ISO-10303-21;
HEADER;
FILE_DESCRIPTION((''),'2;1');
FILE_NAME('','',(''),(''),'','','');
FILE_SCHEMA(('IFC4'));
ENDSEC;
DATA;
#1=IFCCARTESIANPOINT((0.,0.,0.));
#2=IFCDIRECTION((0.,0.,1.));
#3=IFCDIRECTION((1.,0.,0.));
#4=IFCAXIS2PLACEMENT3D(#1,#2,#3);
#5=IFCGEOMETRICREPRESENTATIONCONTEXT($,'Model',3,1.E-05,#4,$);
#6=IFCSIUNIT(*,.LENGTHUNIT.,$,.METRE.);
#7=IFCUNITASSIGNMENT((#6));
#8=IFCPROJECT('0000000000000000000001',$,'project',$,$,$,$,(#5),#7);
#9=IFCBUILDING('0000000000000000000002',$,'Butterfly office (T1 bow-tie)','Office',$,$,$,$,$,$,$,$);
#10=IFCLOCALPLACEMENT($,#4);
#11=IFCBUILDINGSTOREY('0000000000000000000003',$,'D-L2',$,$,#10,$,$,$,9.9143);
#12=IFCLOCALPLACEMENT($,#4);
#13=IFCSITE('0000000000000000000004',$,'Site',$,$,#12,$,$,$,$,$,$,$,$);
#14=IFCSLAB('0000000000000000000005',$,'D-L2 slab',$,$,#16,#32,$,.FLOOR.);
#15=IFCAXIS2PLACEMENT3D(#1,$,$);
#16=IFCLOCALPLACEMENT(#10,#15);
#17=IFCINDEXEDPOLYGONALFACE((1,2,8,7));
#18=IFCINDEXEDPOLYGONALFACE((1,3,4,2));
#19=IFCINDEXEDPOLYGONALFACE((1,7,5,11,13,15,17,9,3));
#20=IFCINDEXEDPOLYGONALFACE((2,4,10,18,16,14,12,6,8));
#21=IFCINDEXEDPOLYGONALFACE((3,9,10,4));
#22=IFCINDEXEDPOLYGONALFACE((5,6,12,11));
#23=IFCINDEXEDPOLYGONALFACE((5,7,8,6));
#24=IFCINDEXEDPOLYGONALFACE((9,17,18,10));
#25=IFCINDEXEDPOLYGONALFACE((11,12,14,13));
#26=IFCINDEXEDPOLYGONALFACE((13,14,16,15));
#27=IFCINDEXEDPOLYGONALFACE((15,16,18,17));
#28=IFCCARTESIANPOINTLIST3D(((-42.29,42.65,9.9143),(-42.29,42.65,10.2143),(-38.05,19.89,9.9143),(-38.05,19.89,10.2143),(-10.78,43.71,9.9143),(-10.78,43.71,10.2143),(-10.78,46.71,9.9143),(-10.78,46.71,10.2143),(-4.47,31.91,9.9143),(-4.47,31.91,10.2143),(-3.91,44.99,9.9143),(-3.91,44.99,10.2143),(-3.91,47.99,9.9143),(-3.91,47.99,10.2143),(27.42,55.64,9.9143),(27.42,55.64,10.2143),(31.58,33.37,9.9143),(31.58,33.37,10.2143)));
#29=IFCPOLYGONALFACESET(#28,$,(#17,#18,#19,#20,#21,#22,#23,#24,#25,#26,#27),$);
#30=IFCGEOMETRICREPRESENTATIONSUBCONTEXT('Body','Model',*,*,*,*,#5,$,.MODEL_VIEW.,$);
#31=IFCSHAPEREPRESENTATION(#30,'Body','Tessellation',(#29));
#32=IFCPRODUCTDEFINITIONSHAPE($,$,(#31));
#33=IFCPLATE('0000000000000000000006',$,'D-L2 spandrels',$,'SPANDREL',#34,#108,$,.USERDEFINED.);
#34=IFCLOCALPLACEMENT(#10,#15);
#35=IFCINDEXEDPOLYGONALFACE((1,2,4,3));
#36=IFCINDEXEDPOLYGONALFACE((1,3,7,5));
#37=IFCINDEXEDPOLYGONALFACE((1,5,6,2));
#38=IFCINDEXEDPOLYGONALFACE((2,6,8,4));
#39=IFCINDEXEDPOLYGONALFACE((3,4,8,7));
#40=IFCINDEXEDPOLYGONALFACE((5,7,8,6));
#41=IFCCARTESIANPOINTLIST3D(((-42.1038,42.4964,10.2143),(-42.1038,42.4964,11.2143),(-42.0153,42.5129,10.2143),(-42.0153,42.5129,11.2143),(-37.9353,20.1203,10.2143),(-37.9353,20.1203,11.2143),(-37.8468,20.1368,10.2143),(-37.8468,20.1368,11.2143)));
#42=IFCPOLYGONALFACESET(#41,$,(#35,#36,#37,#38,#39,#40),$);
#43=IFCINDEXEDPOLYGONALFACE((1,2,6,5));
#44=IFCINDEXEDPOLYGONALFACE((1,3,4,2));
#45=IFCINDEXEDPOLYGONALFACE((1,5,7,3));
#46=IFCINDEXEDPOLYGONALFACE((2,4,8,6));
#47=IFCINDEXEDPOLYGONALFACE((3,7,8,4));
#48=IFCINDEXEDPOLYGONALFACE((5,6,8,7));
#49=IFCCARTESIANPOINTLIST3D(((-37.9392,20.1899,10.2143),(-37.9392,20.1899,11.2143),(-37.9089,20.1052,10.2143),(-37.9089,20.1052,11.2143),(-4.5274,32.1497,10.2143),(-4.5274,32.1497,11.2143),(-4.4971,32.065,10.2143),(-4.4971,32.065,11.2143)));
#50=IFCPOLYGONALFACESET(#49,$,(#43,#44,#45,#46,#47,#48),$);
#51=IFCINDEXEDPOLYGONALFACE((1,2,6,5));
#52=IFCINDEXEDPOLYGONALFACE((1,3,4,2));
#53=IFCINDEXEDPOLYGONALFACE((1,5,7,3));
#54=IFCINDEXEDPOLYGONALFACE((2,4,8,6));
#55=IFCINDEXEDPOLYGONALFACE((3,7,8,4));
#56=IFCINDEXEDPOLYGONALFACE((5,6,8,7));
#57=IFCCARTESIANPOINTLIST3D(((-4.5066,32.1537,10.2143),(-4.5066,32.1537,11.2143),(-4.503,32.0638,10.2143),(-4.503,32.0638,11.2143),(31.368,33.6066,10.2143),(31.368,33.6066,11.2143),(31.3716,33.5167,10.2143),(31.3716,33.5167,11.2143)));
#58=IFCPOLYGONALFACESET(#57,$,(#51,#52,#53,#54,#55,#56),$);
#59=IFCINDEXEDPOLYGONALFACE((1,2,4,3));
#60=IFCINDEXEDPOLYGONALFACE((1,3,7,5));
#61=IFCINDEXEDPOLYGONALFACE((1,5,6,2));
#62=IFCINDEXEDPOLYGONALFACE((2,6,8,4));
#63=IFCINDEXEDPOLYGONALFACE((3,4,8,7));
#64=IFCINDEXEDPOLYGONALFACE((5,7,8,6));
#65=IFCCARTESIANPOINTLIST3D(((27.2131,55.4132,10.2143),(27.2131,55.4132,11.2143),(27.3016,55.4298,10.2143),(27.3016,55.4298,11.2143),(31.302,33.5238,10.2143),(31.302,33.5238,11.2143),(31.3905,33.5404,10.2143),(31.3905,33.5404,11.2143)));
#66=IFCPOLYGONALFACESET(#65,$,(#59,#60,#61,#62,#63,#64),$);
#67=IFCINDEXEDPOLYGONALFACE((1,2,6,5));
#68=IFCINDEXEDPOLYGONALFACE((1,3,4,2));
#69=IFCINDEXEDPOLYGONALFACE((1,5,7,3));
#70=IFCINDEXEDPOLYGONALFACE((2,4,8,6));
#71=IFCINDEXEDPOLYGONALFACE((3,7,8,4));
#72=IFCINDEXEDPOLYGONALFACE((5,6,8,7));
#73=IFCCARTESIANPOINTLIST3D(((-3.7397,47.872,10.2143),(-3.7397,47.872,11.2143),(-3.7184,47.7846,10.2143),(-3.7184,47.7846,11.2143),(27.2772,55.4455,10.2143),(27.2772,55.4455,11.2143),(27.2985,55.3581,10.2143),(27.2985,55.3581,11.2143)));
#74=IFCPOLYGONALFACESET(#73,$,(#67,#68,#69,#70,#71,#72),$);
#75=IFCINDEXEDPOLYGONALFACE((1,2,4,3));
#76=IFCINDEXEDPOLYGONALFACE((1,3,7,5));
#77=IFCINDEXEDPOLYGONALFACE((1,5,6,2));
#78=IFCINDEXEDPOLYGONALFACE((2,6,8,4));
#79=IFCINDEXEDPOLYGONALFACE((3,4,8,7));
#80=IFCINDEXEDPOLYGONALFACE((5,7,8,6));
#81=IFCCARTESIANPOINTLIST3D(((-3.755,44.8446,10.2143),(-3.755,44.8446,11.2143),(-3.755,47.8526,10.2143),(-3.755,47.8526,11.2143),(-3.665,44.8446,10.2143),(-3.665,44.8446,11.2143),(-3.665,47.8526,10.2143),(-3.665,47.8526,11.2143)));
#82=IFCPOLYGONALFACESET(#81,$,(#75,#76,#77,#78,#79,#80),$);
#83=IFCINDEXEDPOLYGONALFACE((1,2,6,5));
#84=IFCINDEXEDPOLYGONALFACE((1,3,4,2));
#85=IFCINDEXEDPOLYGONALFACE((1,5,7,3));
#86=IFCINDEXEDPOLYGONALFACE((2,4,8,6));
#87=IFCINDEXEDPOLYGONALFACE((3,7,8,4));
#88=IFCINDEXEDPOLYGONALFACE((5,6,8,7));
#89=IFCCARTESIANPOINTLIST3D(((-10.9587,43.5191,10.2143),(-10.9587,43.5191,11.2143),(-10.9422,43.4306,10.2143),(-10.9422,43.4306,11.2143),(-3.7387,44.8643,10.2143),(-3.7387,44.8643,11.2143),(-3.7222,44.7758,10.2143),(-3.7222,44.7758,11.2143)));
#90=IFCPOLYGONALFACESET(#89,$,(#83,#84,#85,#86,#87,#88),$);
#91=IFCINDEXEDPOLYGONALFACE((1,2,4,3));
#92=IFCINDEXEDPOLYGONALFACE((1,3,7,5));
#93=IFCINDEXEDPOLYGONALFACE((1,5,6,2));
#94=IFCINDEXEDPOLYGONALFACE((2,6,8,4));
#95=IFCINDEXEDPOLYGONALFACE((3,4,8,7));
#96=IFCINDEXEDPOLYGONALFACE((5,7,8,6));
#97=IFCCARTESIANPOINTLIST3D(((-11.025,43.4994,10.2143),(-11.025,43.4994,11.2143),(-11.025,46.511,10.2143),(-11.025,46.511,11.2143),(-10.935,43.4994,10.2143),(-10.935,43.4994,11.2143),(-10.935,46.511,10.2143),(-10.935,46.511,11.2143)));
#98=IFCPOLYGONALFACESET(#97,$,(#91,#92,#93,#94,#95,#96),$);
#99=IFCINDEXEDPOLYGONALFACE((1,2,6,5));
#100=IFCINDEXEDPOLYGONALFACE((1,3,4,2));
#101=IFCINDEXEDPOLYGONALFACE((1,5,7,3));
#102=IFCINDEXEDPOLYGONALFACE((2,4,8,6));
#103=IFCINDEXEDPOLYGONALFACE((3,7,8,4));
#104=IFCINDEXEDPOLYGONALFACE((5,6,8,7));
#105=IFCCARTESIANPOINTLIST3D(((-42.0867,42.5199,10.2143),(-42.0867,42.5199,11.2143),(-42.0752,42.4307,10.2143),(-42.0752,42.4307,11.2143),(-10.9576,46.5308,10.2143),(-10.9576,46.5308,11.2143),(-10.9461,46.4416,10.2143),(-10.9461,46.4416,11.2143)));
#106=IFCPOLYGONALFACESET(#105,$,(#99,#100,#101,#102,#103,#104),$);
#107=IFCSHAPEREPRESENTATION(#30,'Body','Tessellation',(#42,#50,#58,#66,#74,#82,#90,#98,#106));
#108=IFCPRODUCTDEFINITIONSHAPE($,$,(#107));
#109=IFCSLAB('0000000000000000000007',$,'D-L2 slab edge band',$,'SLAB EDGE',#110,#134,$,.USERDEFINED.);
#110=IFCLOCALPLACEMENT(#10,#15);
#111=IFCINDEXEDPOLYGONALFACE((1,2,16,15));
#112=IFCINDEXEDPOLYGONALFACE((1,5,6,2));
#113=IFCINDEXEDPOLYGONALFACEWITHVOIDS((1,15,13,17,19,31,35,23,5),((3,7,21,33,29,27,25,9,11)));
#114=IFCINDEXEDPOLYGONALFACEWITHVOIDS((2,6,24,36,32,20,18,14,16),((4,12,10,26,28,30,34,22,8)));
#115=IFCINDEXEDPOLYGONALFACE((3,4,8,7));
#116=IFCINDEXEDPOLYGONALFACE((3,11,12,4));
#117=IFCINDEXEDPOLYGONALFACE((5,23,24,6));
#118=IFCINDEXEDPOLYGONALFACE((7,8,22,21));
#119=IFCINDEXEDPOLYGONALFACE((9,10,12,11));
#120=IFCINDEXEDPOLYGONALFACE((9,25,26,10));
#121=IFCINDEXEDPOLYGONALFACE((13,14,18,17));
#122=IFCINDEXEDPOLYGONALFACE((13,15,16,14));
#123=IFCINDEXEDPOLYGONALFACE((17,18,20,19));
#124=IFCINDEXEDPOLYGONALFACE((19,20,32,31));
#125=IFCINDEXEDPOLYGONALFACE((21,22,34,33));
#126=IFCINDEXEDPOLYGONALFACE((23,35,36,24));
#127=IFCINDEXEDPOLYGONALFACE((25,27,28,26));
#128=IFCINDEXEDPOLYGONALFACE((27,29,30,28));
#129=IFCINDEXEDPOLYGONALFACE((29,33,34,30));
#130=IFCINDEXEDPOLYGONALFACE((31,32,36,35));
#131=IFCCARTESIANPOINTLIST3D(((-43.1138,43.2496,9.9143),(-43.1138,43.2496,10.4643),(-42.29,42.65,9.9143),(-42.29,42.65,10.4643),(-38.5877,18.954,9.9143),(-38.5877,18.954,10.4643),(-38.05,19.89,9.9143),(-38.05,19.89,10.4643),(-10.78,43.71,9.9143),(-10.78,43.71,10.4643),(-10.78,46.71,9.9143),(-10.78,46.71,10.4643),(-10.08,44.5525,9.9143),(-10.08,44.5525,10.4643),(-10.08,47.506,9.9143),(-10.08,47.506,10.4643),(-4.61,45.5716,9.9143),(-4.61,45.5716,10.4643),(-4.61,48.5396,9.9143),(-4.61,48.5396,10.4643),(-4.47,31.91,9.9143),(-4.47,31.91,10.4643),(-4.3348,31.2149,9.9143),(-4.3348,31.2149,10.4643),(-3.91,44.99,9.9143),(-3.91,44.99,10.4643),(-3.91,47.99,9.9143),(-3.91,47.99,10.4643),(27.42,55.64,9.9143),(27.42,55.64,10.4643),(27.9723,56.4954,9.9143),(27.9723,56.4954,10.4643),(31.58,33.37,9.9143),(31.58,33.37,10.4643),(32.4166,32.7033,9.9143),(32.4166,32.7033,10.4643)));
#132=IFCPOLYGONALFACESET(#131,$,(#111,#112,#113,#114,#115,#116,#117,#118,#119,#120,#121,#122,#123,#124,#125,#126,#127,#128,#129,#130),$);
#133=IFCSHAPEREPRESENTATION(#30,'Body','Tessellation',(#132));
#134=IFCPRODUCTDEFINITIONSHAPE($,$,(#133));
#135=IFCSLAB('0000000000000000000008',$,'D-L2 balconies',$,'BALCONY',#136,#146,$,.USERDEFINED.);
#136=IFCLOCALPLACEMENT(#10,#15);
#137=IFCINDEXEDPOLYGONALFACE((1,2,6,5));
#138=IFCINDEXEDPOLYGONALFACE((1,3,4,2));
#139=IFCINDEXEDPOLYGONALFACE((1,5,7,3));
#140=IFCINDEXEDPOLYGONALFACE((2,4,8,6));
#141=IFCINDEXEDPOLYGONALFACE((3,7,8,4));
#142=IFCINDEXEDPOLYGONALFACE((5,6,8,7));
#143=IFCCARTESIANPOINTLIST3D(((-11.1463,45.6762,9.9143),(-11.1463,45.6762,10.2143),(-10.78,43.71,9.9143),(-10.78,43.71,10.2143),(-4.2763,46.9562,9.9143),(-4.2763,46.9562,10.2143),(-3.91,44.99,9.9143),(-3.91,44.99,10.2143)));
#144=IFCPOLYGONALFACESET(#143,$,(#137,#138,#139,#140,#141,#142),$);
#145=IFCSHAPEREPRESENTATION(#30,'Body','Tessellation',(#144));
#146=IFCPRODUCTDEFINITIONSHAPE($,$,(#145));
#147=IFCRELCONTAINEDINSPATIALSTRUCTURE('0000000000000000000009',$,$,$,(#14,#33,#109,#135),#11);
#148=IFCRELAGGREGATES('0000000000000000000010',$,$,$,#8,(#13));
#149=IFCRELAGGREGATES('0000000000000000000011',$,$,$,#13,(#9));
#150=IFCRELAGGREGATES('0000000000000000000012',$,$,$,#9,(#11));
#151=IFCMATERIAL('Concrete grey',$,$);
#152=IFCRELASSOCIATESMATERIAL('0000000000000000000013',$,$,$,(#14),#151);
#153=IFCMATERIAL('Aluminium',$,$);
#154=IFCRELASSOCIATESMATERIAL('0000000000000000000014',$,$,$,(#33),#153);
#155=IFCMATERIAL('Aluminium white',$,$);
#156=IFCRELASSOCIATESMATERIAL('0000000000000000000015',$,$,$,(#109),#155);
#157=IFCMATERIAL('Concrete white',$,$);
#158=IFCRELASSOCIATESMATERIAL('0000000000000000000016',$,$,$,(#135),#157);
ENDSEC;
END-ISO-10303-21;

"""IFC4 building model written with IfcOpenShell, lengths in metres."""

from ifc_helpers import new_model, si_unit, frame, origin_with_axes, place, context, subcontext, project, spatial, polyline, outline, extrude, material, element, save


model = new_model("IFC4")

# Units and contexts
model_context = context("Model", 3, precision=1e-05, world=origin_with_axes())
body_context = subcontext(model_context, "Body", "Model", "MODEL_VIEW")
ifc_project = project(units=[si_unit("LENGTHUNIT", "METRE")], contexts=[model_context])

# Site, building, storey
site_placement = place(None, origin_with_axes())
site = spatial("IfcSite", under=ifc_project, at=site_placement, Name="Site")
building = spatial("IfcBuilding", under=site, Name="Butterfly office (T1 bow-tie)", Description="Office")
storey_placement = place(None, origin_with_axes())
storey = spatial("IfcBuildingStorey", under=building, at=storey_placement, Name="D-L2", Elevation=9.9143)

# Shared definitions
ifc_material_1 = material(Name="Aluminium")

# Slab
ifc_material_2 = material(Name="Concrete grey")
slab_1_placement = place(storey_placement, origin_with_axes())
element("IfcSlab", 1, at=slab_1_placement, inside=storey, material=ifc_material_2, Name="D-L2 slab", PredefinedType="FLOOR", context=body_context, shape_type="SweptSolid", body=[
    extrude(outline(polyline([(-42.29, 42.65), (-38.05, 19.89), (-4.47, 31.91), (31.58, 33.37), (27.42, 55.64), (-3.91, 47.99), (-3.91, 44.99), (-10.78, 43.71), (-10.78, 46.71), (-42.29, 42.65)])), frame((0.0, 0.0, 9.9143), z_axis=(0.0, 0.0, 1.0), x_axis=(1.0, 0.0, 0.0)), (0.0, 0.0, 1.0), 0.3),
])

# Plate
plate_placement = place(storey_placement, origin_with_axes())
element("IfcPlate", 2, at=plate_placement, inside=storey, material=ifc_material_1, Name="D-L2 spandrels", ObjectType="SPANDREL", PredefinedType="USERDEFINED", context=body_context, shape_type="SweptSolid", body=[
    extrude(outline(polyline([(-42.1038, 42.4964), (-37.9353, 20.1203), (-37.8468, 20.1368), (-42.0153, 42.5129), (-42.1038, 42.4964)])), frame((0.0, 0.0, 10.2143), z_axis=(0.0, 0.0, 1.0), x_axis=(1.0, 0.0, 0.0)), (0.0, 0.0, 1.0), 1.0),
    extrude(outline(polyline([(-37.9089, 20.1052), (-4.4971, 32.065), (-4.5274, 32.1497), (-37.9392, 20.1899), (-37.9089, 20.1052)])), frame((0.0, 0.0, 10.2143), z_axis=(0.0, 0.0, 1.0), x_axis=(1.0, 0.0, 0.0)), (0.0, 0.0, 1.0), 1.0),
    extrude(outline(polyline([(-4.503, 32.0638), (31.3716, 33.5167), (31.368, 33.6066), (-4.5066, 32.1537), (-4.503, 32.0638)])), frame((0.0, 0.0, 10.2143), z_axis=(0.0, 0.0, 1.0), x_axis=(1.0, 0.0, 0.0)), (0.0, 0.0, 1.0), 1.0),
    extrude(outline(polyline([(31.3905, 33.5404), (27.3016, 55.4298), (27.2131, 55.4132), (31.302, 33.5238), (31.3905, 33.5404)])), frame((0.0, 0.0, 10.2143), z_axis=(0.0, 0.0, 1.0), x_axis=(1.0, 0.0, 0.0)), (0.0, 0.0, 1.0), 1.0),
    extrude(outline(polyline([(27.2772, 55.4455), (-3.7397, 47.872), (-3.7184, 47.7846), (27.2985, 55.3581), (27.2772, 55.4455)])), frame((0.0, 0.0, 10.2143), z_axis=(0.0, 0.0, 1.0), x_axis=(1.0, 0.0, 0.0)), (0.0, 0.0, 1.0), 1.0),
    extrude(outline(polyline([(-3.755, 47.8526), (-3.755, 44.8446), (-3.665, 44.8446), (-3.665, 47.8526), (-3.755, 47.8526)])), frame((0.0, 0.0, 10.2143), z_axis=(0.0, 0.0, 1.0), x_axis=(1.0, 0.0, 0.0)), (0.0, 0.0, 1.0), 1.0),
    extrude(outline(polyline([(-3.7387, 44.8643), (-10.9587, 43.5191), (-10.9422, 43.4306), (-3.7222, 44.7758), (-3.7387, 44.8643)])), frame((0.0, 0.0, 10.2143), z_axis=(0.0, 0.0, 1.0), x_axis=(1.0, 0.0, 0.0)), (0.0, 0.0, 1.0), 1.0),
    extrude(outline(polyline([(-10.935, 43.4994), (-10.935, 46.511), (-11.025, 46.511), (-11.025, 43.4994), (-10.935, 43.4994)])), frame((0.0, 0.0, 10.2143), z_axis=(0.0, 0.0, 1.0), x_axis=(1.0, 0.0, 0.0)), (0.0, 0.0, 1.0), 1.0),
    extrude(outline(polyline([(-10.9576, 46.5308), (-42.0867, 42.5199), (-42.0752, 42.4307), (-10.9461, 46.4416), (-10.9576, 46.5308)])), frame((0.0, 0.0, 10.2143), z_axis=(0.0, 0.0, 1.0), x_axis=(1.0, 0.0, 0.0)), (0.0, 0.0, 1.0), 1.0),
])

# Slabs
ifc_material_3 = material(Name="Aluminium white")
slab_2_placement = place(storey_placement, origin_with_axes())
element("IfcSlab", 3, at=slab_2_placement, inside=storey, material=ifc_material_3, Name="D-L2 slab edge band", ObjectType="SLAB EDGE", PredefinedType="USERDEFINED", context=body_context, shape_type="SweptSolid", body=[
    extrude(outline(polyline([(-43.1138, 43.2496), (-38.5877, 18.954), (-4.3348, 31.2149), (32.4166, 32.7033), (27.9723, 56.4954), (-4.61, 48.5396), (-4.61, 45.5716), (-10.08, 44.5525), (-10.08, 47.506), (-43.1138, 43.2496)]), holes=[polyline([(-42.29, 42.65), (-38.05, 19.89), (-4.47, 31.91), (31.58, 33.37), (27.42, 55.64), (-3.91, 47.99), (-3.91, 44.99), (-10.78, 43.71), (-10.78, 46.71), (-42.29, 42.65)])]), frame((0.0, 0.0, 9.9143), z_axis=(0.0, 0.0, 1.0), x_axis=(1.0, 0.0, 0.0)), (0.0, 0.0, 1.0), 0.55),
])
ifc_material_4 = material(Name="Concrete white")
slab_3_placement = place(storey_placement, origin_with_axes())
element("IfcSlab", 4, at=slab_3_placement, inside=storey, material=ifc_material_4, Name="D-L2 balconies", ObjectType="BALCONY", PredefinedType="USERDEFINED", context=body_context, shape_type="SweptSolid", body=[
    extrude(outline(polyline([(-3.91, 44.99), (-10.78, 43.71), (-11.1463, 45.6762), (-4.2763, 46.9562), (-3.91, 44.99)])), frame((0.0, 0.0, 9.9143), z_axis=(0.0, 0.0, 1.0), x_axis=(1.0, 0.0, 0.0)), (0.0, 0.0, 1.0), 0.3),
])

save(model, "model.ifc")
